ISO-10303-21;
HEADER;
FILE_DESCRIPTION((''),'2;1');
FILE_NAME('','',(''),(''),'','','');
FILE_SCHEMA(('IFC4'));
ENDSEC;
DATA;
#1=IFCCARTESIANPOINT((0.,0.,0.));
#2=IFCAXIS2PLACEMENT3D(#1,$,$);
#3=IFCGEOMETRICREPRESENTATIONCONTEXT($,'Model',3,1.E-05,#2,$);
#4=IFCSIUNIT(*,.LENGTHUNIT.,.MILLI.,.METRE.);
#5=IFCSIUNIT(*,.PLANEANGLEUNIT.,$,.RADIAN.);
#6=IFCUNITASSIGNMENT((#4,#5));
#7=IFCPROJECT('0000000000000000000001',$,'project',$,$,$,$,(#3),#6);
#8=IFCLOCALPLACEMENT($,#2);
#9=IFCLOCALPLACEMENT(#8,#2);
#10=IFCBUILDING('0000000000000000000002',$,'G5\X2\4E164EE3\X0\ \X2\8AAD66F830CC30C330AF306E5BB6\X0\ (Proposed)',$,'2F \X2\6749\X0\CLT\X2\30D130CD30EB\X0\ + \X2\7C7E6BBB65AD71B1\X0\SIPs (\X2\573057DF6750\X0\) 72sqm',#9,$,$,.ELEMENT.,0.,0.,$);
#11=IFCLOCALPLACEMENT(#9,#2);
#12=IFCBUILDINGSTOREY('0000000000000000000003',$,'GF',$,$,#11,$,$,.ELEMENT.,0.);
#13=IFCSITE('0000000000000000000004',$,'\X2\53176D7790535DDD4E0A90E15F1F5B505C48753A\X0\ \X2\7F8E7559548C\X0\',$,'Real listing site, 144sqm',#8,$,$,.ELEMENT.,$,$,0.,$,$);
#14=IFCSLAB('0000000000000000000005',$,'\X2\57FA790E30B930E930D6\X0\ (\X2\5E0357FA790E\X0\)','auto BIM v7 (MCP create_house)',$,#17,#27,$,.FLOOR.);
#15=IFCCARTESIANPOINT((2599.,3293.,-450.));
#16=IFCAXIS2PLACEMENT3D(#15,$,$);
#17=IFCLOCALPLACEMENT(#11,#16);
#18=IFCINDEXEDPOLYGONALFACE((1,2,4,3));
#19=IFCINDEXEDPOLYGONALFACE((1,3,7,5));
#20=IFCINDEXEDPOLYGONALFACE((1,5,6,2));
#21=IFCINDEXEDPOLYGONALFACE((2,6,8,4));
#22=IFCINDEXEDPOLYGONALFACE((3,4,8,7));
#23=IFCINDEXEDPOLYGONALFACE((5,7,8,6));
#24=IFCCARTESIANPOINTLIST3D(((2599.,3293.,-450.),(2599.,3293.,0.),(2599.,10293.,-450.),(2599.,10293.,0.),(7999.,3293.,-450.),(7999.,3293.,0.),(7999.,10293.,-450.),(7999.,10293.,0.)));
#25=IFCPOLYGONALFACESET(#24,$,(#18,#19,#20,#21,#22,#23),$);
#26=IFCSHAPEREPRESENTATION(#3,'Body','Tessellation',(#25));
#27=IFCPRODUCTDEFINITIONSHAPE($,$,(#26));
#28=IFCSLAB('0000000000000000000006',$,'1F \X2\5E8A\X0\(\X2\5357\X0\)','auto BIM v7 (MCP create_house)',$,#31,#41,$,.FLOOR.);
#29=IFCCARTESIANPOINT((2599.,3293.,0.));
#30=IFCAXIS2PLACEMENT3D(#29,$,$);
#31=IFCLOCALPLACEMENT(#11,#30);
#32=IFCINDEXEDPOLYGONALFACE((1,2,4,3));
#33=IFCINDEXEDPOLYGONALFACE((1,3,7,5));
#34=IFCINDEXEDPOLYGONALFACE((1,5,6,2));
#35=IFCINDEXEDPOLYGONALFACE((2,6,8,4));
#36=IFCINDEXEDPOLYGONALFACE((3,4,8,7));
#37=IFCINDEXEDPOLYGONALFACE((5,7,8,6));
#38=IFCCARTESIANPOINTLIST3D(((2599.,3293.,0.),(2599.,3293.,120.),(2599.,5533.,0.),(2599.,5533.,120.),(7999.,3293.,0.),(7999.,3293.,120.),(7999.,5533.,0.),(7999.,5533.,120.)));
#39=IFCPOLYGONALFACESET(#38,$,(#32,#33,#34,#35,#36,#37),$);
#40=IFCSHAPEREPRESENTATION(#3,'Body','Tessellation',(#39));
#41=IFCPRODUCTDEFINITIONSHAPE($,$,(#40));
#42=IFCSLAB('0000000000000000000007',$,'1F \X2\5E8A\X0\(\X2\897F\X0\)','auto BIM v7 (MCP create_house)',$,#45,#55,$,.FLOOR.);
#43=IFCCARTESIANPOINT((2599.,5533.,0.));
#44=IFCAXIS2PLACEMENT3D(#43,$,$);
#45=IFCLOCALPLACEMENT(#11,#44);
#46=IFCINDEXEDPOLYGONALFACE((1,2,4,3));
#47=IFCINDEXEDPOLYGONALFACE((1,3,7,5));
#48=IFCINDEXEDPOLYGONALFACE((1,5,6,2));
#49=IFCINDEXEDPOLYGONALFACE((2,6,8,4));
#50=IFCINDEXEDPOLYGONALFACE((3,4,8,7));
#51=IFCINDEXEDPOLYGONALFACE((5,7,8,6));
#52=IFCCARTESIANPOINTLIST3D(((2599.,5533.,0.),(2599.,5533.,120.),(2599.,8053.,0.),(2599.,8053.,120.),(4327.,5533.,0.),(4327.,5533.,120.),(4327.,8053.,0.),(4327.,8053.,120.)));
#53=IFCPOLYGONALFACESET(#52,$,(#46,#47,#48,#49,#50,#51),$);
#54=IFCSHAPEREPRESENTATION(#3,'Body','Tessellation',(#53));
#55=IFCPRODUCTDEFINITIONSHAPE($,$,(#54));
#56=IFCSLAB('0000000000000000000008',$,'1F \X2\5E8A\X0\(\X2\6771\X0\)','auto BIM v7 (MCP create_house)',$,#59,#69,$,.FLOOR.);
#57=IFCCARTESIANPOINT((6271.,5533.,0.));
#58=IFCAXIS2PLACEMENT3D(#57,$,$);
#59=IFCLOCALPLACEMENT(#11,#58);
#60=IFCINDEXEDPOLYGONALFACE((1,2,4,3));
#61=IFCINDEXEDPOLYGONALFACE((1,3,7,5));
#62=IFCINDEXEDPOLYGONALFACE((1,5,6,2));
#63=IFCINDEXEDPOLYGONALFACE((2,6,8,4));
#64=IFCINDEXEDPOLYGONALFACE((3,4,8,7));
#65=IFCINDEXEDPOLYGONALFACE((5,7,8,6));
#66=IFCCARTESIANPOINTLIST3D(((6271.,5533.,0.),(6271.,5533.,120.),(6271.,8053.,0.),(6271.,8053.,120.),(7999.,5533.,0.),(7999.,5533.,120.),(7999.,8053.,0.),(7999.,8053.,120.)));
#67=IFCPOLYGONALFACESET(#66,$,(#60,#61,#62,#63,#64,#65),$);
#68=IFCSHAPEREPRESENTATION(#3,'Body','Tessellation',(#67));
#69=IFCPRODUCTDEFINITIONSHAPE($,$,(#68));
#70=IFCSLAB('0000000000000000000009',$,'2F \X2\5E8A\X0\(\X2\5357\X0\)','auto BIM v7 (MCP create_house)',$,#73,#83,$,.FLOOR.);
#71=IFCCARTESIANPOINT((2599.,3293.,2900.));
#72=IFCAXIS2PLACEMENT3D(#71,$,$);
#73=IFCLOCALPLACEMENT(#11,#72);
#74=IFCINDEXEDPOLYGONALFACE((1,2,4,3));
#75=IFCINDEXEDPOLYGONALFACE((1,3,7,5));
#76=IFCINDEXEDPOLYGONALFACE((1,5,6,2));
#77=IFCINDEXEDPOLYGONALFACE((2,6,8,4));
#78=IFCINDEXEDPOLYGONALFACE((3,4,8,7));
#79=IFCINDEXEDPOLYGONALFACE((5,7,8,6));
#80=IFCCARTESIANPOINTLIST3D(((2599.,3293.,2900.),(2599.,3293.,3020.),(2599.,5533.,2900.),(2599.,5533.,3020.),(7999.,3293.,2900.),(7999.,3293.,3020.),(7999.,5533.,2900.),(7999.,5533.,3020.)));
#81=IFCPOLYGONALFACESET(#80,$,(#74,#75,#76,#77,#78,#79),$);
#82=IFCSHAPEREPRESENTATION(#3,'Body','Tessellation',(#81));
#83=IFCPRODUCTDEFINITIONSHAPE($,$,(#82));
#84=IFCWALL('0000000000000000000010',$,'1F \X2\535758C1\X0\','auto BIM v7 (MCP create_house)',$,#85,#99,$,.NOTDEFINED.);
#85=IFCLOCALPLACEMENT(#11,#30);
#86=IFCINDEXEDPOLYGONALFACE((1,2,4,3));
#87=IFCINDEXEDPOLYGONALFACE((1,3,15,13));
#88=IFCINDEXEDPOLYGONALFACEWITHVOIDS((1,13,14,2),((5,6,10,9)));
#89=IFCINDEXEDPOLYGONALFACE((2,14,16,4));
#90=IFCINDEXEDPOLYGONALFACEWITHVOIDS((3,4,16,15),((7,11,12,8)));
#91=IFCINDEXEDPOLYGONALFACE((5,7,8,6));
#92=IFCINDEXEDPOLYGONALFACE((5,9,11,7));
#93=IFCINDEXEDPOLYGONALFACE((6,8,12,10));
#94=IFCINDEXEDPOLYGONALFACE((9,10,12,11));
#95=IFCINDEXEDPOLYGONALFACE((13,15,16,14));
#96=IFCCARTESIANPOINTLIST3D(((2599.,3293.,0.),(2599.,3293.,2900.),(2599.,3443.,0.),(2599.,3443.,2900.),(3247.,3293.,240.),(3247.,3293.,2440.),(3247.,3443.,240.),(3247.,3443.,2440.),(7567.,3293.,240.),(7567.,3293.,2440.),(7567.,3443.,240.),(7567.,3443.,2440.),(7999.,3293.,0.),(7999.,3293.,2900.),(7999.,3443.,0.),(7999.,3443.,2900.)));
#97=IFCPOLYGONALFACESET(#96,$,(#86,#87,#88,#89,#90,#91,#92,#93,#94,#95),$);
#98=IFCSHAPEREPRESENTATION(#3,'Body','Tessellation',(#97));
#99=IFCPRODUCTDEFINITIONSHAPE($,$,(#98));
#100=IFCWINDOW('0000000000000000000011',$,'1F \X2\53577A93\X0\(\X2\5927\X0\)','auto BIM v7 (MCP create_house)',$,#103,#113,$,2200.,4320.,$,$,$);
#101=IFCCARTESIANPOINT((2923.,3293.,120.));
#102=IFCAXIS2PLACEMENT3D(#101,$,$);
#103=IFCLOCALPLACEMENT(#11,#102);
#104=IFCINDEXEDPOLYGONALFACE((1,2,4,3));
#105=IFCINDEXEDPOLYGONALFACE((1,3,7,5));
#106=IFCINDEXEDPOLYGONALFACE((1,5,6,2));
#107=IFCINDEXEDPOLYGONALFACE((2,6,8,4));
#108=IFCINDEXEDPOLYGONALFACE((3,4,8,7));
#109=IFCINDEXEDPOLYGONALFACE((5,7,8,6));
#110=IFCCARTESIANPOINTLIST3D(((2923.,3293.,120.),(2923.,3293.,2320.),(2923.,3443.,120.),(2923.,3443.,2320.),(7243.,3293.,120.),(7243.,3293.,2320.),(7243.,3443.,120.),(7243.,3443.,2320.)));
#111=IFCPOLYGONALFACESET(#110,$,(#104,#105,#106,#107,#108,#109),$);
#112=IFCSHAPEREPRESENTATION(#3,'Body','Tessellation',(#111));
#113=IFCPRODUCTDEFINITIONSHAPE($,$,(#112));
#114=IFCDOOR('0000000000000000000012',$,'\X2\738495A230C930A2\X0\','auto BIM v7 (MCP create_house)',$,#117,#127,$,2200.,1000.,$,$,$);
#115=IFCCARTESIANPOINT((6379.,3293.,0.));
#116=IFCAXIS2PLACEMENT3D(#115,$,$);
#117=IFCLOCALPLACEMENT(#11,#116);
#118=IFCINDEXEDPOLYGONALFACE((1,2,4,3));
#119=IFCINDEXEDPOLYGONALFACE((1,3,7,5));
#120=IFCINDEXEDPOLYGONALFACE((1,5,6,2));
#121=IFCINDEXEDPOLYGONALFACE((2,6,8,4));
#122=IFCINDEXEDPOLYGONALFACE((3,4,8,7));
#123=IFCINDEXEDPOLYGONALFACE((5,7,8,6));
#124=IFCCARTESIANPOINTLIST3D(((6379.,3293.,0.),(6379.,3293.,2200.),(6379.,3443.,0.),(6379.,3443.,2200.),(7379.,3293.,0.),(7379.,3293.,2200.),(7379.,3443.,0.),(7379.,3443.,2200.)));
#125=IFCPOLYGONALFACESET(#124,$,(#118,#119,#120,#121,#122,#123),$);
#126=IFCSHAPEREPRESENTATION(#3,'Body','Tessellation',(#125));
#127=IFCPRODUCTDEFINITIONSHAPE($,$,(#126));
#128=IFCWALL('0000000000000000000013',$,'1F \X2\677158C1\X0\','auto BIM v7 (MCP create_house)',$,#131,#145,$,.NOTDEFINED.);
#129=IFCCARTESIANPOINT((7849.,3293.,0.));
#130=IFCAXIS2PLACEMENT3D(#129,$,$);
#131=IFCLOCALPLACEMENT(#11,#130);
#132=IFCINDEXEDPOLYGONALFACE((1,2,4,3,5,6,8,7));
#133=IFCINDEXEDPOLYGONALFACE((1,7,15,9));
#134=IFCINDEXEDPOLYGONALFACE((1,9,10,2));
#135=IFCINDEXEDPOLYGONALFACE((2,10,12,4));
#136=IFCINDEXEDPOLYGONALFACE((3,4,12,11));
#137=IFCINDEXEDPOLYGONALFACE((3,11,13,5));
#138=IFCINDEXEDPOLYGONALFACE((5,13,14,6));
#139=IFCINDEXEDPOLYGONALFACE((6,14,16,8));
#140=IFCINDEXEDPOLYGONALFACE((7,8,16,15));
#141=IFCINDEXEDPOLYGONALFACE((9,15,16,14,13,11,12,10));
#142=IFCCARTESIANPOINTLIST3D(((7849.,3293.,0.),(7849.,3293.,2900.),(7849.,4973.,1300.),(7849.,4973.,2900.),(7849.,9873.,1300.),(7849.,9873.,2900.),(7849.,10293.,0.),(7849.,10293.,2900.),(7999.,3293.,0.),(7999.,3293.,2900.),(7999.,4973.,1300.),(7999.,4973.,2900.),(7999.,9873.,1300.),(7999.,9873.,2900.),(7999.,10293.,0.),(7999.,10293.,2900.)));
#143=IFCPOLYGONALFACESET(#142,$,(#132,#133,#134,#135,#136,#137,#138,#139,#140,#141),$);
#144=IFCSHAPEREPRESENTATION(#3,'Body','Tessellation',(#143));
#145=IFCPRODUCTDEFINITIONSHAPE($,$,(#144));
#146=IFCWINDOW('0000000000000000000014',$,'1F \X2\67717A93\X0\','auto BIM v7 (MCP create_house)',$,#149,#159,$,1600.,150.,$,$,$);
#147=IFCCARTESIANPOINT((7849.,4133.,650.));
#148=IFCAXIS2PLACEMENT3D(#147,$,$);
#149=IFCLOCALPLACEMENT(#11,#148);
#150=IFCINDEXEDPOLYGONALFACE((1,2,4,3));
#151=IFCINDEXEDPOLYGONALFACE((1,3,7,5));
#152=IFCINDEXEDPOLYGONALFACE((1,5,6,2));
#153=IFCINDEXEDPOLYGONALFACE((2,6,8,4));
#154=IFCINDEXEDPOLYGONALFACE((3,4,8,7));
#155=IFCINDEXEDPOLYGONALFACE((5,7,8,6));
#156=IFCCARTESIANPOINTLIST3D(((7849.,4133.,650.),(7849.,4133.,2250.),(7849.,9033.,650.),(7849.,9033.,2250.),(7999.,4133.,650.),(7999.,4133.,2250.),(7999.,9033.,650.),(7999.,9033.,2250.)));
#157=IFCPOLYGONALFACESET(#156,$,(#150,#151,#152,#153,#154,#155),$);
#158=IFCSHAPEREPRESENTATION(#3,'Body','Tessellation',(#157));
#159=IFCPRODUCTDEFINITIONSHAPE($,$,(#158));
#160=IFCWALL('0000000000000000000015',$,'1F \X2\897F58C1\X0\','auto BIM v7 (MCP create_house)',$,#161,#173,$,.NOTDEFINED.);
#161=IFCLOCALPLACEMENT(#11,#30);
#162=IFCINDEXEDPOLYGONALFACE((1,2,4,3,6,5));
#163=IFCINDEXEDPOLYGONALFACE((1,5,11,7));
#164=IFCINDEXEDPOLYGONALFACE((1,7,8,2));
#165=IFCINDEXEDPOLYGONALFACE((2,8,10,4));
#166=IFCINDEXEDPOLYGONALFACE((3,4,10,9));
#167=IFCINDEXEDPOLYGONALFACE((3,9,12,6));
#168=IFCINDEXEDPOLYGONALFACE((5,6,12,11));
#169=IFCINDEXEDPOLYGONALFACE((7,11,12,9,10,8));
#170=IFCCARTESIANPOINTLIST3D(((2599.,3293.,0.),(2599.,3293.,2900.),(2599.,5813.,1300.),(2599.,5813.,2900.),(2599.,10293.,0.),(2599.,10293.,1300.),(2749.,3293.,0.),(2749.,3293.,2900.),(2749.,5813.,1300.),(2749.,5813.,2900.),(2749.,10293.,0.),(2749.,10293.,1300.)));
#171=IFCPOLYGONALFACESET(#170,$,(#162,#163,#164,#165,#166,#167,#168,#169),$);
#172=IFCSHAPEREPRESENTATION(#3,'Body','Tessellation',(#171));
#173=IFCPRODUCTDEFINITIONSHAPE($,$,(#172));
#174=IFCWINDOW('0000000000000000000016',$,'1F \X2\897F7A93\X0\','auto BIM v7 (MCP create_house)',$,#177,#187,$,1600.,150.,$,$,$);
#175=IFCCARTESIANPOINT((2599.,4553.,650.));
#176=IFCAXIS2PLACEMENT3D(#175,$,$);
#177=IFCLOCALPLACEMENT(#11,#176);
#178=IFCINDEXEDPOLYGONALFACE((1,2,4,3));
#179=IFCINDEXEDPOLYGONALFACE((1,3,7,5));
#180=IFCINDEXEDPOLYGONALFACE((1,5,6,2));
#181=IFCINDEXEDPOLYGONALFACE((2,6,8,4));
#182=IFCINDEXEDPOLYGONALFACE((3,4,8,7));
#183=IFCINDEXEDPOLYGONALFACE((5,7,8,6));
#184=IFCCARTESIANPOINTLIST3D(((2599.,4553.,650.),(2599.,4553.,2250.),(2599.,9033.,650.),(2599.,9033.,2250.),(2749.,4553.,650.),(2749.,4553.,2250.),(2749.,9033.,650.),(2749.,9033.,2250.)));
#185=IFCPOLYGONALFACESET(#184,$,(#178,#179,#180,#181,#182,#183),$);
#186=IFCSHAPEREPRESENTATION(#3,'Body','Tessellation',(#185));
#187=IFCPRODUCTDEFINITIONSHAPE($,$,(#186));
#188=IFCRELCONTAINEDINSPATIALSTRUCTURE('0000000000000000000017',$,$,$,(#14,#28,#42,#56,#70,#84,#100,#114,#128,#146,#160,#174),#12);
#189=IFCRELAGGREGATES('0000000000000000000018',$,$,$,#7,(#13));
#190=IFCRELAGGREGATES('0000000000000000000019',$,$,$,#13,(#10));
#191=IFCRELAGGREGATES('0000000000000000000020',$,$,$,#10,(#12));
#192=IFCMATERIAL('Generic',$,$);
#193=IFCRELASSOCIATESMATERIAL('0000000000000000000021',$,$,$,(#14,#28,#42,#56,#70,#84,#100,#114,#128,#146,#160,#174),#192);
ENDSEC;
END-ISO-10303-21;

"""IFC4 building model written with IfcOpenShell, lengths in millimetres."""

from ifc_helpers import new_model, si_unit, frame, frame_2d, origin, place, context, project, spatial, rectangle, extrude, material, element, fill, save


model = new_model("IFC4")

# Units and contexts
model_context = context("Model", 3, precision=1e-05, world=origin())
ifc_project = project(units=[si_unit("LENGTHUNIT", "METRE", prefix="MILLI"), si_unit("PLANEANGLEUNIT", "RADIAN")], contexts=[model_context])

# Site, building, storey
site_placement = place(None, origin())
site = spatial("IfcSite", under=ifc_project, at=site_placement, Name="北海道川上郡弟子屈町 美留和", ObjectType="Real listing site, 144sqm", CompositionType="ELEMENT", RefElevation=0.0)
building_placement = place(site_placement, origin())
building = spatial("IfcBuilding", under=site, at=building_placement, Name="G5世代 読書ヌックの家 (Proposed)", ObjectType="2F 杉CLTパネル + 籾殻断熱SIPs (地域材) 72sqm", CompositionType="ELEMENT", ElevationOfRefHeight=0.0, ElevationOfTerrain=0.0)
storey_placement = place(building_placement, origin())
storey = spatial("IfcBuildingStorey", under=building, at=storey_placement, Name="GF", CompositionType="ELEMENT", Elevation=0.0)

# Slabs
ifc_material = material(Name="Generic")
slab_1_placement = place(storey_placement, frame((2599.0, 3293.0, -450.0)))
element("IfcSlab", 1, at=slab_1_placement, inside=storey, material=ifc_material, Name="基礎スラブ (布基礎)", Description="auto BIM v7 (MCP create_house)", PredefinedType="FLOOR", context=model_context, shape_type="SweptSolid", body=[
    extrude(rectangle(XDim=5400.0, YDim=7000.0, at=frame_2d((2700.0, 3500.0))), frame((2599.0, 3293.0, -450.0)), (0.0, 0.0, 1.0), 450.0),
])
slab_2_placement = place(storey_placement, frame((2599.0, 3293.0, 0.0)))
element("IfcSlab", 2, at=slab_2_placement, inside=storey, material=ifc_material, Name="1F 床(南)", Description="auto BIM v7 (MCP create_house)", PredefinedType="FLOOR", context=model_context, shape_type="SweptSolid", body=[
    extrude(rectangle(XDim=5400.0, YDim=2240.0, at=frame_2d((2700.0, 1120.0))), frame((2599.0, 3293.0, 0.0)), (0.0, 0.0, 1.0), 120.0),
])
slab_3_placement = place(storey_placement, frame((2599.0, 5533.0, 0.0)))
element("IfcSlab", 3, at=slab_3_placement, inside=storey, material=ifc_material, Name="1F 床(西)", Description="auto BIM v7 (MCP create_house)", PredefinedType="FLOOR", context=model_context, shape_type="SweptSolid", body=[
    extrude(rectangle(XDim=1728.0, YDim=2520.0, at=frame_2d((864.0, 1260.0))), frame((2599.0, 5533.0, 0.0)), (0.0, 0.0, 1.0), 120.0),
])
slab_4_placement = place(storey_placement, frame((6271.0, 5533.0, 0.0)))
element("IfcSlab", 4, at=slab_4_placement, inside=storey, material=ifc_material, Name="1F 床(東)", Description="auto BIM v7 (MCP create_house)", PredefinedType="FLOOR", context=model_context, shape_type="SweptSolid", body=[
    extrude(rectangle(XDim=1728.0, YDim=2520.0, at=frame_2d((864.0, 1260.0))), frame((6271.0, 5533.0, 0.0)), (0.0, 0.0, 1.0), 120.0),
])
slab_5_placement = place(storey_placement, frame((2599.0, 3293.0, 2900.0)))
element("IfcSlab", 5, at=slab_5_placement, inside=storey, material=ifc_material, Name="2F 床(南)", Description="auto BIM v7 (MCP create_house)", PredefinedType="FLOOR", context=model_context, shape_type="SweptSolid", body=[
    extrude(rectangle(XDim=5400.0, YDim=2240.0, at=frame_2d((2700.0, 1120.0))), frame((2599.0, 3293.0, 2900.0)), (0.0, 0.0, 1.0), 120.0),
])

# Wall, openings, window, door
wall_1_placement = place(storey_placement, frame((2599.0, 3293.0, 0.0)))
wall_1 = element("IfcWall", 6, at=wall_1_placement, inside=storey, material=ifc_material, Name="1F 南壁", Description="auto BIM v7 (MCP create_house)", PredefinedType="NOTDEFINED", context=model_context, shape_type="SweptSolid", body=[
    extrude(rectangle(XDim=5400.0, YDim=150.0, at=frame_2d((2700.0, 75.0))), frame((2599.0, 3293.0, 0.0)), (0.0, 0.0, 1.0), 2900.0),
])
opening_1_placement = place(storey_placement, frame((2923.0, 3293.0, 120.0)))
opening_1 = element("IfcOpeningElement", 7, at=opening_1_placement, cuts=wall_1, PredefinedType="NOTDEFINED", context=model_context, shape_type="SweptSolid", body=[
    extrude(rectangle(XDim=4320.0, YDim=150.0, at=frame_2d((2160.0, 75.0))), frame((2923.0, 3293.0, 120.0)), (0.0, 0.0, 1.0), 2200.0),
])
opening_2_placement = place(storey_placement, frame((6379.0, 3293.0, 0.0)))
opening_2 = element("IfcOpeningElement", 8, at=opening_2_placement, cuts=wall_1, PredefinedType="NOTDEFINED", context=model_context, shape_type="SweptSolid", body=[
    extrude(rectangle(XDim=1000.0, YDim=150.0, at=frame_2d((500.0, 75.0))), frame((6379.0, 3293.0, 0.0)), (0.0, 0.0, 1.0), 2200.0),
])
window_1_placement = place(storey_placement, frame((2923.0, 3293.0, 120.0)))
window_1 = element("IfcWindow", 9, at=window_1_placement, inside=storey, material=ifc_material, Name="1F 南窓(大)", Description="auto BIM v7 (MCP create_house)", OverallHeight=2200.0, OverallWidth=4320.0, context=model_context, shape_type="SweptSolid", body=[
    extrude(rectangle(XDim=4320.0, YDim=150.0, at=frame_2d((2160.0, 75.0))), frame((2923.0, 3293.0, 120.0)), (0.0, 0.0, 1.0), 2200.0),
])
fill(opening_1, window_1)
door_placement = place(storey_placement, frame((6379.0, 3293.0, 0.0)))
door = element("IfcDoor", 10, at=door_placement, inside=storey, material=ifc_material, Name="玄関ドア", Description="auto BIM v7 (MCP create_house)", OverallHeight=2200.0, OverallWidth=1000.0, context=model_context, shape_type="SweptSolid", body=[
    extrude(rectangle(XDim=1000.0, YDim=150.0, at=frame_2d((500.0, 75.0))), frame((6379.0, 3293.0, 0.0)), (0.0, 0.0, 1.0), 2200.0),
])
fill(opening_2, door)

# Walls, openings, windows
wall_2_placement = place(storey_placement, frame((7849.0, 3293.0, 0.0)))
wall_2 = element("IfcWall", 11, at=wall_2_placement, inside=storey, material=ifc_material, Name="1F 東壁", Description="auto BIM v7 (MCP create_house)", PredefinedType="NOTDEFINED", context=model_context, shape_type="SweptSolid", body=[
    extrude(rectangle(XDim=150.0, YDim=7000.0, at=frame_2d((75.0, 3500.0))), frame((7849.0, 3293.0, 0.0)), (0.0, 0.0, 1.0), 2900.0),
])
opening_3_placement = place(storey_placement, frame((7849.0, 4133.0, 650.0)))
opening_3 = element("IfcOpeningElement", 12, at=opening_3_placement, cuts=wall_2, PredefinedType="NOTDEFINED", context=model_context, shape_type="SweptSolid", body=[
    extrude(rectangle(XDim=150.0, YDim=4900.0, at=frame_2d((75.0, 2450.0))), frame((7849.0, 4133.0, 650.0)), (0.0, 0.0, 1.0), 1600.0),
])
window_2_placement = place(storey_placement, frame((7849.0, 4133.0, 650.0)))
window_2 = element("IfcWindow", 13, at=window_2_placement, inside=storey, material=ifc_material, Name="1F 東窓", Description="auto BIM v7 (MCP create_house)", OverallHeight=1600.0, OverallWidth=150.0, context=model_context, shape_type="SweptSolid", body=[
    extrude(rectangle(XDim=150.0, YDim=4900.0, at=frame_2d((75.0, 2450.0))), frame((7849.0, 4133.0, 650.0)), (0.0, 0.0, 1.0), 1600.0),
])
fill(opening_3, window_2)
wall_3_placement = place(storey_placement, frame((2599.0, 3293.0, 0.0)))
wall_3 = element("IfcWall", 14, at=wall_3_placement, inside=storey, material=ifc_material, Name="1F 西壁", Description="auto BIM v7 (MCP create_house)", PredefinedType="NOTDEFINED", context=model_context, shape_type="SweptSolid", body=[
    extrude(rectangle(XDim=150.0, YDim=7000.0, at=frame_2d((75.0, 3500.0))), frame((2599.0, 3293.0, 0.0)), (0.0, 0.0, 1.0), 2900.0),
])
opening_4_placement = place(storey_placement, frame((2599.0, 4553.0, 650.0)))
opening_4 = element("IfcOpeningElement", 15, at=opening_4_placement, cuts=wall_3, PredefinedType="NOTDEFINED", context=model_context, shape_type="SweptSolid", body=[
    extrude(rectangle(XDim=150.0, YDim=4480.0, at=frame_2d((75.0, 2240.0))), frame((2599.0, 4553.0, 650.0)), (0.0, 0.0, 1.0), 1600.0),
])
window_3_placement = place(storey_placement, frame((2599.0, 4553.0, 650.0)))
window_3 = element("IfcWindow", 16, at=window_3_placement, inside=storey, material=ifc_material, Name="1F 西窓", Description="auto BIM v7 (MCP create_house)", OverallHeight=1600.0, OverallWidth=150.0, context=model_context, shape_type="SweptSolid", body=[
    extrude(rectangle(XDim=150.0, YDim=4480.0, at=frame_2d((75.0, 2240.0))), frame((2599.0, 4553.0, 650.0)), (0.0, 0.0, 1.0), 1600.0),
])
fill(opening_4, window_3)

save(model, "model.ifc")
